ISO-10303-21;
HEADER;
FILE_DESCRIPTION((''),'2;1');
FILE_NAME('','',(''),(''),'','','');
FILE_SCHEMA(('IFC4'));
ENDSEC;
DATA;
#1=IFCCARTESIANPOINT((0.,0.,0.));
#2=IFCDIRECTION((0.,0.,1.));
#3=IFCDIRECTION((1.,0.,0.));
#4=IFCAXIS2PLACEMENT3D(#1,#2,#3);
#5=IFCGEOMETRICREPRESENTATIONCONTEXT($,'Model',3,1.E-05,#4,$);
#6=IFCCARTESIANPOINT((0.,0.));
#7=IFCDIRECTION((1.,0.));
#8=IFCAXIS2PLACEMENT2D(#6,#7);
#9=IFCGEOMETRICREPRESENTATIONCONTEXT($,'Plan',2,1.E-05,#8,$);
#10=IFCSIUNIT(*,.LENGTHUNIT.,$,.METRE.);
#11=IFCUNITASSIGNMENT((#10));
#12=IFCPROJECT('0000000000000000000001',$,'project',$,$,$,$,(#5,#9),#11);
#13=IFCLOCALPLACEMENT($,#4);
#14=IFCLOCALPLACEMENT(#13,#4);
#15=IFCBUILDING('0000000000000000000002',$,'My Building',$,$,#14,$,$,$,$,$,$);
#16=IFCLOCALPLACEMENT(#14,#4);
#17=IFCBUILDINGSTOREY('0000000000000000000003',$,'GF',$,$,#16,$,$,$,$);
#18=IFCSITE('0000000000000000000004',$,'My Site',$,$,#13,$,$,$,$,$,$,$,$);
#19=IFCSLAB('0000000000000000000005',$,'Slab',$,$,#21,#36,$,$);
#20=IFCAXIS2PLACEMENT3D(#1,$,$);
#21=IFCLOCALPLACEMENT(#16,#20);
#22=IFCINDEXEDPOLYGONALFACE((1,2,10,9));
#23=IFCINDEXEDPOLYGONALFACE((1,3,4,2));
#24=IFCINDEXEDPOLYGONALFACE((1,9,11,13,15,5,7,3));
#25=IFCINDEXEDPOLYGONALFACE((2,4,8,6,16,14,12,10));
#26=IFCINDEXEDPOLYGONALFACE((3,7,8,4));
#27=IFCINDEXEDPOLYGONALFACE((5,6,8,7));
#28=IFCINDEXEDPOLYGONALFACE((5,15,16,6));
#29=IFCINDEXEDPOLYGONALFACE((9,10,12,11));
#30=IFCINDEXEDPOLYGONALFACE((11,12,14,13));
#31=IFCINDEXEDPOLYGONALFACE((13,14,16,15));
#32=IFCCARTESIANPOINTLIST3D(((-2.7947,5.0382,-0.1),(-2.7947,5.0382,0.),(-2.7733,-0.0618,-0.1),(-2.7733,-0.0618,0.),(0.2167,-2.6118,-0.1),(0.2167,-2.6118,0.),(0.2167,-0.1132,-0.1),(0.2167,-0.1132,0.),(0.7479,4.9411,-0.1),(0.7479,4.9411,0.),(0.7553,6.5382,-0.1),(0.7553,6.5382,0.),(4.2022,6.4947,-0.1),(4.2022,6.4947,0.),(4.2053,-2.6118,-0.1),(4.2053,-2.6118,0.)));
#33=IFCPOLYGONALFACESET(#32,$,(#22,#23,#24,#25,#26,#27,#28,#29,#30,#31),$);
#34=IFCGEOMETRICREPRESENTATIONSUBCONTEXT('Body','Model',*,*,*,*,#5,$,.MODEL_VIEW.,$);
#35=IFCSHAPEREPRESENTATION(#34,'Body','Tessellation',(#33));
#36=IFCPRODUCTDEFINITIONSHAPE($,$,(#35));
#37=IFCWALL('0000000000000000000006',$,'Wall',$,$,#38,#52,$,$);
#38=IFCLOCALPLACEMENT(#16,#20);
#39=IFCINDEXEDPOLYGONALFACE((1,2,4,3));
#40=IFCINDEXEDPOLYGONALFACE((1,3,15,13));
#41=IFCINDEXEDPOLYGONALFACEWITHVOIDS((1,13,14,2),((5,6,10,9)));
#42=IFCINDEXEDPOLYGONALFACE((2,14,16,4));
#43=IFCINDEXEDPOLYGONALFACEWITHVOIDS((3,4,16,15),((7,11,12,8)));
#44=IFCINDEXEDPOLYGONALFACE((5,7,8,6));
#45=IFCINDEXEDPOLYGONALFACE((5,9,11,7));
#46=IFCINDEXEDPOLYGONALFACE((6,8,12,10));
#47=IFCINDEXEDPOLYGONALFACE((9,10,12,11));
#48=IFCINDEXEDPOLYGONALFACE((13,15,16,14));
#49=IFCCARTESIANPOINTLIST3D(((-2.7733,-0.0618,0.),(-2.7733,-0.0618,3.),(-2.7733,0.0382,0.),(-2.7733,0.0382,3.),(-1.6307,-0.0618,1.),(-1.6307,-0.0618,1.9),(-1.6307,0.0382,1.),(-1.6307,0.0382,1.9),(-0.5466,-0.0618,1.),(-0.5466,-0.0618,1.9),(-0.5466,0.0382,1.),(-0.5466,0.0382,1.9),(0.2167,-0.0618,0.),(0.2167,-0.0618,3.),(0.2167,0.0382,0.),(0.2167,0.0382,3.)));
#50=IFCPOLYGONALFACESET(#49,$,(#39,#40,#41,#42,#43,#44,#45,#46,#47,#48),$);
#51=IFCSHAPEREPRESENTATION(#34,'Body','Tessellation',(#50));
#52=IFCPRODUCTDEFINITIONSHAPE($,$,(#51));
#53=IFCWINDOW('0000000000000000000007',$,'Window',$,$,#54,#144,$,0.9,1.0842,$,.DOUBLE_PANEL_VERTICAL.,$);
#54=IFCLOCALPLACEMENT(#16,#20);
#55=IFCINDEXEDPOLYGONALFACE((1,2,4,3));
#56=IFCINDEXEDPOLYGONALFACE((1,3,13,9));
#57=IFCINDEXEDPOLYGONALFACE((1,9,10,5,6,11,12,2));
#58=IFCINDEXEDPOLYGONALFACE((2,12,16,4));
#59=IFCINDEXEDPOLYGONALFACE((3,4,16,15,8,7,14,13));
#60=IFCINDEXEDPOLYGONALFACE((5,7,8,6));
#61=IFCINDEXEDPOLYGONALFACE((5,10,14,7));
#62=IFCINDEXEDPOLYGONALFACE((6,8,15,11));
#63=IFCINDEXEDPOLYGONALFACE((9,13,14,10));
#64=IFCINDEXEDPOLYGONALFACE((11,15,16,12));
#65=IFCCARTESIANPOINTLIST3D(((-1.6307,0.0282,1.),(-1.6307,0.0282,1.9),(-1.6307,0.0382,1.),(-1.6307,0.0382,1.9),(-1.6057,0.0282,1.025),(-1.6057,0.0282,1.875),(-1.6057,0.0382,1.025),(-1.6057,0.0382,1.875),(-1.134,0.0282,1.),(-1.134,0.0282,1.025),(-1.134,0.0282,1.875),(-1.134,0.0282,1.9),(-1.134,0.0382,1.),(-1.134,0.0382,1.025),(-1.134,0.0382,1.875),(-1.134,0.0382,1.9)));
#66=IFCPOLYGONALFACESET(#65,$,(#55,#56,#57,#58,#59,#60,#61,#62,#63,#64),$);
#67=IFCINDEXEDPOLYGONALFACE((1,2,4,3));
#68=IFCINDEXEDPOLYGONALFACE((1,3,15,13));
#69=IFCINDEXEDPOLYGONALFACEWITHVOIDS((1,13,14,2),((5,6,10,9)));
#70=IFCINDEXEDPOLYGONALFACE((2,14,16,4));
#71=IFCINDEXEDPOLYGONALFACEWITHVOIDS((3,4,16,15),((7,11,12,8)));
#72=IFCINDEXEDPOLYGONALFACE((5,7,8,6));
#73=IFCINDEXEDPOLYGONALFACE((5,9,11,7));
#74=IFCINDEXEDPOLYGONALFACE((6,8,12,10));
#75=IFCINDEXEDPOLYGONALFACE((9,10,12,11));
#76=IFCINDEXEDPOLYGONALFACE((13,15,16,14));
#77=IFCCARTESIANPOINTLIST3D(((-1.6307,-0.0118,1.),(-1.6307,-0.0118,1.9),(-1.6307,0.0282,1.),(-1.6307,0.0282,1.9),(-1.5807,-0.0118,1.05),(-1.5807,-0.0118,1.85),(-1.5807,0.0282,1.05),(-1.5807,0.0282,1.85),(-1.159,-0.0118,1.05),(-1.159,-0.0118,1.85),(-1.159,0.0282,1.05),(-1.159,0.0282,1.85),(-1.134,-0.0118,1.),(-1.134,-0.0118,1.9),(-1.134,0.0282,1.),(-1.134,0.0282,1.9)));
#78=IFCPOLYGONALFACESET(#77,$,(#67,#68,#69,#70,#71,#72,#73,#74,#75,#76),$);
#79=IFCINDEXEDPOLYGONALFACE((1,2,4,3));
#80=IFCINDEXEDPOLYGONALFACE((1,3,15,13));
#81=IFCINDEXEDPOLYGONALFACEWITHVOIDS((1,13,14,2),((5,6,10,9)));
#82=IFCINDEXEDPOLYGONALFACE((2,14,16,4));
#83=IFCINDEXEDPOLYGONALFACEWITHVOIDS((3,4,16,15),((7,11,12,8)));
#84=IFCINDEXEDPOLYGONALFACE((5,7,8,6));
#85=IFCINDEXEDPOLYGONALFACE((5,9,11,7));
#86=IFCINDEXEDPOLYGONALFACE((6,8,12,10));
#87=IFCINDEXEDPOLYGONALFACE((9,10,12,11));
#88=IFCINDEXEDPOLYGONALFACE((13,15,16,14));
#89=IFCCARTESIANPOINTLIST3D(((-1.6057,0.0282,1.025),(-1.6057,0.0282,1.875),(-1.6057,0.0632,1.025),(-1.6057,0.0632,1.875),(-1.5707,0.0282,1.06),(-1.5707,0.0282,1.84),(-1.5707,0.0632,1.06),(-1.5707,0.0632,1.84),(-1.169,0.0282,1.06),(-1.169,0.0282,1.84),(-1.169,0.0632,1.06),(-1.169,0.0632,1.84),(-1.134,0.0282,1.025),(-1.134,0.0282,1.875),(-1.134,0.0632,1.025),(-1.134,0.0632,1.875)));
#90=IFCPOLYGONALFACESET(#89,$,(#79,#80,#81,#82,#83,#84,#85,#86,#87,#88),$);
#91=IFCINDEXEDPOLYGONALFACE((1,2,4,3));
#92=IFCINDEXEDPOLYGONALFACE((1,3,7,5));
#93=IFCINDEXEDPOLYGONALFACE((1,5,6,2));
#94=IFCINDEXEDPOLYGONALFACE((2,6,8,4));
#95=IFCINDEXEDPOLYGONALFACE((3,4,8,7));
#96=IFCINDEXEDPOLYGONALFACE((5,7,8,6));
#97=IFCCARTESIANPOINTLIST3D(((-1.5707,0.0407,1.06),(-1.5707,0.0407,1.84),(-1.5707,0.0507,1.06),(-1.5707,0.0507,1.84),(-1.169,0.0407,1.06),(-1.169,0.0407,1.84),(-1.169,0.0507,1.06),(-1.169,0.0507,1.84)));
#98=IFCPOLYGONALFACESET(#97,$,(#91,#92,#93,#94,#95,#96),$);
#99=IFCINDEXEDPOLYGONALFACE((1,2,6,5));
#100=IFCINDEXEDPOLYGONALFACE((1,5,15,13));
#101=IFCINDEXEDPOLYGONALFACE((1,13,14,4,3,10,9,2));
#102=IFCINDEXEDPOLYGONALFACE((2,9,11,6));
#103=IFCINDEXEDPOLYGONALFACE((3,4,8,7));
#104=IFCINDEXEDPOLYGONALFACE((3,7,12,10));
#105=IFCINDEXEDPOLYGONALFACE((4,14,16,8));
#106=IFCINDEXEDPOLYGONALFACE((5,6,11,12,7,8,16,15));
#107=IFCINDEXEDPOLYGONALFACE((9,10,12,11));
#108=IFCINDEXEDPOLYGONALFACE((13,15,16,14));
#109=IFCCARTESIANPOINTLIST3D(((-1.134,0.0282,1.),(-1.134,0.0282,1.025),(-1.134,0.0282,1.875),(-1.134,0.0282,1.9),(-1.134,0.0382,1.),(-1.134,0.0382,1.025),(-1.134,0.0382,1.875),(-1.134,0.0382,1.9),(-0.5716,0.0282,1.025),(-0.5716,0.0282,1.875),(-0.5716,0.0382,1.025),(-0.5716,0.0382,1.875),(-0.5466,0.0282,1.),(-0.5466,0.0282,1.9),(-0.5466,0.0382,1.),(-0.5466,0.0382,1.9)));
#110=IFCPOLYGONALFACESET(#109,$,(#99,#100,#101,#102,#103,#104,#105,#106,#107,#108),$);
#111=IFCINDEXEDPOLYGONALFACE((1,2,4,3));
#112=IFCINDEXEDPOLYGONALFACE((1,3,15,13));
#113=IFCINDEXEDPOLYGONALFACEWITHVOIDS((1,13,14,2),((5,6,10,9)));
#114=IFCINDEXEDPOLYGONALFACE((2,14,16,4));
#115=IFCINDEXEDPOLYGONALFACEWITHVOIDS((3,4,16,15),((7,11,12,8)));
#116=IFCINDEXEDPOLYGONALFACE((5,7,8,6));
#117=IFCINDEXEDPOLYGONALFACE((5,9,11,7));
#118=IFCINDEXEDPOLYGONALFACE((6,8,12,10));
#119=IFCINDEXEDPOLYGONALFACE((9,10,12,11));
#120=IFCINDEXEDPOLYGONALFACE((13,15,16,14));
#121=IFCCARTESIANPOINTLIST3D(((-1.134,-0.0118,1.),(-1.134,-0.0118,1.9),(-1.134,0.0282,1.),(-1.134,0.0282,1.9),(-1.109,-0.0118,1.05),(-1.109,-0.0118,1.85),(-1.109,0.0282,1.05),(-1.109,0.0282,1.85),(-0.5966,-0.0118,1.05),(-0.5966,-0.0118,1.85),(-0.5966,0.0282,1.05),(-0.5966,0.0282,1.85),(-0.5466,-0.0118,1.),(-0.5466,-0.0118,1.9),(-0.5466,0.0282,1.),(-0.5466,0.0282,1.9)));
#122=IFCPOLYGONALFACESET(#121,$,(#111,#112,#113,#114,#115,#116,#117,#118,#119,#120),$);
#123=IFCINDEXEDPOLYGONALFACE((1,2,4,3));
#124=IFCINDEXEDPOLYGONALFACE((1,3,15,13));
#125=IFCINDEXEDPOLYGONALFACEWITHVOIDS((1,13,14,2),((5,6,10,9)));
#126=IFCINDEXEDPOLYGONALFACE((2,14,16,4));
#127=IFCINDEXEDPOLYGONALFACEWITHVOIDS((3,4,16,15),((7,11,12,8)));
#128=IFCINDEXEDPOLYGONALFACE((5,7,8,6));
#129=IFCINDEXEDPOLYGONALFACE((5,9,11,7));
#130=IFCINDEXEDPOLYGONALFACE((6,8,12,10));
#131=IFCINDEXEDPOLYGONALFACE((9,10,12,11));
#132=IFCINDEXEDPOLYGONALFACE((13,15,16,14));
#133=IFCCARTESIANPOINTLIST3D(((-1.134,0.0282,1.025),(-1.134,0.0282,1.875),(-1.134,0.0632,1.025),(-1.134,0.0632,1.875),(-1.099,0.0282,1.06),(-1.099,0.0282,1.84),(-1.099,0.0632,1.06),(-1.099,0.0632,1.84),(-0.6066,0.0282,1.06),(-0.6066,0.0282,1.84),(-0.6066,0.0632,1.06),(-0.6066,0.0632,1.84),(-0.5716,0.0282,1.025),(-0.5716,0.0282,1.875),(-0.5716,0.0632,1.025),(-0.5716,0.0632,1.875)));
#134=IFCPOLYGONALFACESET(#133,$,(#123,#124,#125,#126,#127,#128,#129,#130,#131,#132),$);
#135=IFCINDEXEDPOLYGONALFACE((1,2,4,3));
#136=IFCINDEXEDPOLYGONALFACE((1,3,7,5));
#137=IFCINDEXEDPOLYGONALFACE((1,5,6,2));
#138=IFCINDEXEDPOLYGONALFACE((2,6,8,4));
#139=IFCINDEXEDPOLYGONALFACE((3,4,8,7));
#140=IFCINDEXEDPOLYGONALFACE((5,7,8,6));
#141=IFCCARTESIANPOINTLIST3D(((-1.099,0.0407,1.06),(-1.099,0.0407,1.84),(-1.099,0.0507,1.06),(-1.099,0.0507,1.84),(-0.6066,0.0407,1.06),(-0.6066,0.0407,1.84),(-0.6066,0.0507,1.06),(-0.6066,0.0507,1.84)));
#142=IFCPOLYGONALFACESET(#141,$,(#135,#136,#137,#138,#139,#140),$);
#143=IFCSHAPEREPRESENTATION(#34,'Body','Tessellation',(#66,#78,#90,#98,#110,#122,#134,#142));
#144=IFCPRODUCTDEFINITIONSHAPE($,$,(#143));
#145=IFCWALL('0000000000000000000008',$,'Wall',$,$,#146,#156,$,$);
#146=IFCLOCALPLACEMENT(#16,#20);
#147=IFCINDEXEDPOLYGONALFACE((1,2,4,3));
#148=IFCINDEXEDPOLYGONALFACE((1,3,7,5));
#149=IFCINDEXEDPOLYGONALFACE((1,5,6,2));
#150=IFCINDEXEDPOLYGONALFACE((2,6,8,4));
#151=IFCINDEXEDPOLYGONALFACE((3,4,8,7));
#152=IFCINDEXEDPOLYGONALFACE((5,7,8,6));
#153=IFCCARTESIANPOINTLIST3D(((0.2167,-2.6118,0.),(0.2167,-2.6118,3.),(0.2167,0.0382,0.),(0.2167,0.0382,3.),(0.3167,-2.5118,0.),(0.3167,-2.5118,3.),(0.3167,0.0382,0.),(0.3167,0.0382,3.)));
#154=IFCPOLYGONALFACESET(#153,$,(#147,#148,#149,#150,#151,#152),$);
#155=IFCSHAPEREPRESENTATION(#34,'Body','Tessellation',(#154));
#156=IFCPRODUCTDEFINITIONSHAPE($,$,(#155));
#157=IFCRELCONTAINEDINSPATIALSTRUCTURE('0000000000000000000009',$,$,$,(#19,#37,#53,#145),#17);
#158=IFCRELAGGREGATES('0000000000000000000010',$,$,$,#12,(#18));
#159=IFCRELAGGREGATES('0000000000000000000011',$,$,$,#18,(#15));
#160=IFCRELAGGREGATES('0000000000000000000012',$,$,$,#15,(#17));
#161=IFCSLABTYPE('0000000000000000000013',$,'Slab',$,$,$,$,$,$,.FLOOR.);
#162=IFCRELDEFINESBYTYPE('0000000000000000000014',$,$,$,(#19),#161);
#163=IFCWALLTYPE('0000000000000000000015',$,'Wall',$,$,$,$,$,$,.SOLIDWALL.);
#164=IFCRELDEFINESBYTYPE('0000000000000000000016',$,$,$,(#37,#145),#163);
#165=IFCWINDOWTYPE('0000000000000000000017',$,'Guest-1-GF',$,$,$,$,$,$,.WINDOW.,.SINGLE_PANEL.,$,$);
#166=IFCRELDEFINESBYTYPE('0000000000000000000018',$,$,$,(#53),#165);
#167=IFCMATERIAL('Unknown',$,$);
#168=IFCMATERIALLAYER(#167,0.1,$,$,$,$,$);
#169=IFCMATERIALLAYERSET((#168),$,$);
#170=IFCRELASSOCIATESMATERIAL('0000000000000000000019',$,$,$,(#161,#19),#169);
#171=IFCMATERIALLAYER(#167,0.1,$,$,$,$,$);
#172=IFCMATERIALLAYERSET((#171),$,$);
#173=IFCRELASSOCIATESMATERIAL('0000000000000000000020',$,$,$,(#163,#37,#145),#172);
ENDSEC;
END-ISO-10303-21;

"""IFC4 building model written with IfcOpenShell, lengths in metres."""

from ifc_helpers import new_model, entity, si_unit, frame, origin_with_axes, origin_2d_with_axis, place, context, subcontext, project, spatial, line, indexed_curve, outline, extrude, shape, source, transform, mapped, material, layer, layer_set, layer_usage, type_object, type_shapes, element, fill, save


model = new_model("IFC4")

# Units and contexts
model_context = context("Model", 3, precision=1e-05, world=origin_with_axes())
plan_context = context("Plan", 2, precision=1e-05, world=origin_2d_with_axis())
body_context_1 = subcontext(model_context, "Body", "Model", "MODEL_VIEW")
body_context_2 = subcontext(plan_context, "Body", "Plan", "PLAN_VIEW")
ifc_project = project(units=[si_unit("LENGTHUNIT", "METRE")], contexts=[model_context, plan_context])

# Site, building, storey
site_placement = place(None, origin_with_axes())
site = spatial("IfcSite", under=ifc_project, at=site_placement, Name="My Site")
building_placement = place(site_placement, origin_with_axes())
building = spatial("IfcBuilding", under=site, at=building_placement, Name="My Building")
storey_placement = place(building_placement, origin_with_axes())
storey = spatial("IfcBuildingStorey", under=building, at=storey_placement, Name="GF")

# Slab
ifc_material = material(Name="Unknown")
ifc_layer_1 = layer(ifc_material, 0.1)
ifc_layer_set_1 = layer_set([ifc_layer_1])
ifc_layer_usage_1 = layer_usage(ifc_layer_set_1, "AXIS3", "POSITIVE", -0.1)
slab_type = type_object("IfcSlabType", Name="Slab", PredefinedType="FLOOR", material=ifc_layer_set_1)
slab_placement = place(storey_placement, frame((4.2022, 6.4947, 0.0), z_axis=(0.0, 0.0, 1.0), x_axis=(1.0, 0.0, 0.0)))
element("IfcSlab", 1, at=slab_placement, inside=storey, type_object=slab_type, material=ifc_layer_usage_1, Name="Slab", context=body_context_1, shape_type="SweptSolid", body=[
    extrude(outline(indexed_curve([(0.0, 0.0), (-3.4469, 0.0435), (-3.4543, -1.5535), (-6.9969, -1.4565), (-6.9755, -6.5565), (-3.9855, -6.6078), (-3.9855, -9.1065), (0.0031, -9.1065), (0.0, 0.0)])), frame((0.0, 0.0, -0.1), z_axis=(0.0, 0.0, 1.0), x_axis=(1.0, 0.0, 0.0)), (0.0, 0.0, 1.0), 0.1),
])

# Wall, opening, window
ifc_layer_2 = layer(ifc_material, 0.1)
ifc_layer_set_2 = layer_set([ifc_layer_2])
ifc_layer_usage_2 = layer_usage(ifc_layer_set_2, "AXIS2", "POSITIVE", 0.0)
wall_type = type_object("IfcWallType", Name="Wall", PredefinedType="SOLIDWALL", material=ifc_layer_set_2)
wall_1_placement = place(storey_placement, frame((0.2167, 0.0382, 0.0), z_axis=(0.0, 0.0, 1.0), x_axis=(-1.0, 0.0, 0.0)))
wall_1 = element("IfcWall", 2, at=wall_1_placement, inside=storey, type_object=wall_type, material=ifc_layer_usage_2, Name="Wall", context=body_context_1, shape_type="SweptSolid", body=[
    extrude(outline(indexed_curve([(0.0, 0.0), (0.0, 0.1), (2.99, 0.1), (2.99, 0.0)], segments=[line(1, 2, 3, 4, 1)])), origin_with_axes(), (0.0, 0.0, 1.0), 3.0),
])
shared_shape_1 = source(origin_with_axes(), body_context_1, "Body", "SweptSolid", [
    extrude(outline(indexed_curve([(0.0, 0.0), (1.0842, 0.0), (1.0842, 0.9), (0.0, 0.9)], segments=[line(1, 2, 3, 4, 1)])), frame((0.0, -0.6, 0.0), z_axis=(0.0, -1.0, 0.0), x_axis=(1.0, 0.0, 0.0)), (0.0, 0.0, -1.0), 1.2),
])
opening_1_placement = place(wall_1_placement, frame((1.8474, 0.1, 1.0), z_axis=(0.0, 0.0, 1.0), x_axis=(-1.0, 0.0, 0.0)))
opening_1 = element("IfcOpeningElement", 3, at=opening_1_placement, cuts=wall_1, PredefinedType="OPENING", context=body_context_1, shape_type="MappedRepresentation", body=[
    mapped(shared_shape_1, transform((0.0, 0.0, 0.0), x_axis=(1.0, 0.0, 0.0), y_axis=(0.0, 1.0, 0.0), z_axis=(0.0, 0.0, 1.0), scale=1.0)),
])
window_type_1 = type_object("IfcWindowType", Name="Guest-1-GF", PartitioningType="SINGLE_PANEL", PredefinedType="WINDOW")
shared_shape_2 = source(origin_with_axes(), body_context_1, "Body", "SweptSolid", [
    extrude(outline(indexed_curve([(0.4967, 0.0), (0.0, 0.0), (0.0, 0.9), (0.4967, 0.9), (0.4967, 0.875), (0.025, 0.875), (0.025, 0.025), (0.4967, 0.025)], segments=[line(1, 2, 3, 4, 5, 6, 7, 8, 1)])), frame((0.0, 0.09, 0.0), z_axis=(0.0, -1.0, 0.0), x_axis=(1.0, 0.0, 0.0)), (0.0, 0.0, -1.0), 0.01),
    extrude(outline(indexed_curve([(0.0, 0.0), (0.4967, 0.0), (0.4967, 0.9), (0.0, 0.9)], segments=[line(1, 2, 3, 4, 1)]), holes=[indexed_curve([(0.05, 0.05), (0.4717, 0.05), (0.4717, 0.85), (0.05, 0.85)], segments=[line(1, 2, 3, 4, 1)])]), frame((0.0, 0.05, 0.0), z_axis=(0.0, -1.0, 0.0), x_axis=(1.0, 0.0, 0.0)), (0.0, 0.0, -1.0), 0.04),
    extrude(outline(indexed_curve([(0.0, 0.0), (0.4717, 0.0), (0.4717, 0.85), (0.0, 0.85)], segments=[line(1, 2, 3, 4, 1)]), holes=[indexed_curve([(0.035, 0.035), (0.4367, 0.035), (0.4367, 0.815), (0.035, 0.815)], segments=[line(1, 2, 3, 4, 1)])]), frame((0.025, 0.09, 0.025), z_axis=(0.0, -1.0, 0.0), x_axis=(1.0, 0.0, 0.0)), (0.0, 0.0, -1.0), 0.035),
    extrude(outline(indexed_curve([(0.035, 0.035), (0.4367, 0.035), (0.4367, 0.815), (0.035, 0.815)], segments=[line(1, 2, 3, 4, 1)])), frame((0.025, 0.1025, 0.025), z_axis=(0.0, -1.0, 0.0), x_axis=(1.0, 0.0, 0.0)), (0.0, 0.0, -1.0), 0.01),
    extrude(outline(indexed_curve([(0.0, 0.9), (0.5874, 0.9), (0.5874, 0.0), (0.0, 0.0), (0.0, 0.025), (0.5624, 0.025), (0.5624, 0.875), (0.0, 0.875)], segments=[line(1, 2, 3, 4, 5, 6, 7, 8, 1)])), frame((0.4967, 0.09, 0.0), z_axis=(0.0, -1.0, 0.0), x_axis=(1.0, 0.0, 0.0)), (0.0, 0.0, -1.0), 0.01),
    extrude(outline(indexed_curve([(0.0, 0.0), (0.5874, 0.0), (0.5874, 0.9), (0.0, 0.9)], segments=[line(1, 2, 3, 4, 1)]), holes=[indexed_curve([(0.025, 0.05), (0.5374, 0.05), (0.5374, 0.85), (0.025, 0.85)], segments=[line(1, 2, 3, 4, 1)])]), frame((0.4967, 0.05, 0.0), z_axis=(0.0, -1.0, 0.0), x_axis=(1.0, 0.0, 0.0)), (0.0, 0.0, -1.0), 0.04),
    extrude(outline(indexed_curve([(0.0, 0.0), (0.5624, 0.0), (0.5624, 0.85), (0.0, 0.85)], segments=[line(1, 2, 3, 4, 1)]), holes=[indexed_curve([(0.035, 0.035), (0.5274, 0.035), (0.5274, 0.815), (0.035, 0.815)], segments=[line(1, 2, 3, 4, 1)])]), frame((0.4967, 0.09, 0.025), z_axis=(0.0, -1.0, 0.0), x_axis=(1.0, 0.0, 0.0)), (0.0, 0.0, -1.0), 0.035),
    extrude(outline(indexed_curve([(0.035, 0.035), (0.5274, 0.035), (0.5274, 0.815), (0.035, 0.815)], segments=[line(1, 2, 3, 4, 1)])), frame((0.4967, 0.1025, 0.025), z_axis=(0.0, -1.0, 0.0), x_axis=(1.0, 0.0, 0.0)), (0.0, 0.0, -1.0), 0.01),
])
shared_shape_3 = source(origin_with_axes(), body_context_2, "Body", "Curve2D", [
    entity("IfcIndexedPolyCurve", entity("IfcCartesianPointList2D", [[0.05, 0.05], [0.4717, 0.05]])),
    entity("IfcIndexedPolyCurve", entity("IfcCartesianPointList2D", [[0.0, 0.1], [0.025, 0.1], [0.025, 0.09], [0.05, 0.09], [0.05, 0.05], [0.0, 0.05]]), [entity("IfcLineIndex", [1, 2, 3, 4, 5, 6, 1])]),
    entity("IfcIndexedPolyCurve", entity("IfcCartesianPointList2D", [[0.4967, 0.1], [0.4967, 0.1], [0.4967, 0.09], [0.4717, 0.09], [0.4717, 0.05], [0.4967, 0.05]])),
    entity("IfcIndexedPolyCurve", entity("IfcCartesianPointList2D", [[0.025, 0.09], [0.06, 0.09], [0.06, 0.125], [0.025, 0.125]]), [entity("IfcLineIndex", [1, 2, 3, 4, 1])]),
    entity("IfcIndexedPolyCurve", entity("IfcCartesianPointList2D", [[0.4967, 0.09], [0.4617, 0.09], [0.4617, 0.125], [0.4967, 0.125]]), [entity("IfcLineIndex", [1, 2, 3, 4, 1])]),
    entity("IfcIndexedPolyCurve", entity("IfcCartesianPointList2D", [[0.06, 0.09], [0.4617, 0.09]])),
    entity("IfcIndexedPolyCurve", entity("IfcCartesianPointList2D", [[0.06, 0.125], [0.4617, 0.125]])),
    entity("IfcIndexedPolyCurve", entity("IfcCartesianPointList2D", [[0.06, 0.1075], [0.4617, 0.1075]])),
    entity("IfcIndexedPolyCurve", entity("IfcCartesianPointList2D", [[0.5217, 0.05], [1.0342, 0.05]])),
    entity("IfcIndexedPolyCurve", entity("IfcCartesianPointList2D", [[0.4967, 0.1], [0.4967, 0.1], [0.4967, 0.09], [0.5217, 0.09], [0.5217, 0.05], [0.4967, 0.05]])),
    entity("IfcIndexedPolyCurve", entity("IfcCartesianPointList2D", [[1.0842, 0.1], [1.0592, 0.1], [1.0592, 0.09], [1.0342, 0.09], [1.0342, 0.05], [1.0842, 0.05]]), [entity("IfcLineIndex", [1, 2, 3, 4, 5, 6, 1])]),
    entity("IfcIndexedPolyCurve", entity("IfcCartesianPointList2D", [[0.4967, 0.09], [0.5317, 0.09], [0.5317, 0.125], [0.4967, 0.125]]), [entity("IfcLineIndex", [1, 2, 3, 4, 1])]),
    entity("IfcIndexedPolyCurve", entity("IfcCartesianPointList2D", [[1.0592, 0.09], [1.0242, 0.09], [1.0242, 0.125], [1.0592, 0.125]]), [entity("IfcLineIndex", [1, 2, 3, 4, 1])]),
    entity("IfcIndexedPolyCurve", entity("IfcCartesianPointList2D", [[0.5317, 0.09], [1.0242, 0.09]])),
    entity("IfcIndexedPolyCurve", entity("IfcCartesianPointList2D", [[0.5317, 0.125], [1.0242, 0.125]])),
    entity("IfcIndexedPolyCurve", entity("IfcCartesianPointList2D", [[0.5317, 0.1075], [1.0242, 0.1075]])),
])
type_shapes(window_type_1, [shared_shape_2, shared_shape_3])
window_1_placement = place(opening_1_placement, frame((0.0, 0.0, 0.0), z_axis=(0.0, 0.0, 1.0), x_axis=(1.0, 0.0, 0.0)))
window_1 = element("IfcWindow", 4, at=window_1_placement, inside=storey, type_object=window_type_1, Name="Window", OverallHeight=0.9, OverallWidth=1.0842, PartitioningType="DOUBLE_PANEL_VERTICAL", shapes=[
    shape(body_context_1, "Body", "MappedRepresentation", [mapped(shared_shape_2, transform((0.0, 0.0, 0.0), x_axis=(1.0, 0.0, 0.0), y_axis=(0.0, 1.0, 0.0), z_axis=(0.0, 0.0, 1.0), scale=1.0))]),
    shape(body_context_2, "Body", "MappedRepresentation", [mapped(shared_shape_3, transform((0.0, 0.0, 0.0), x_axis=(1.0, 0.0, 0.0), y_axis=(0.0, 1.0, 0.0), z_axis=(0.0, 0.0, 1.0), scale=1.0))]),
])
fill(opening_1, window_1)

# Wall
ifc_layer_usage_3 = layer_usage(ifc_layer_set_2, "AXIS2", "POSITIVE", 0.0)
wall_2_placement = place(storey_placement, frame((0.2167, 0.0382, 0.0), z_axis=(0.0, 0.0, 1.0), x_axis=(0.0, -1.0, 0.0)))
element("IfcWall", 5, at=wall_2_placement, inside=storey, type_object=wall_type, material=ifc_layer_usage_3, Name="Wall", context=body_context_1, shape_type="SweptSolid", body=[
    extrude(outline(indexed_curve([(0.0, 0.0), (0.0, 0.1), (2.55, 0.1), (2.65, 0.0)], segments=[line(1, 2, 3, 4, 1)])), origin_with_axes(), (0.0, 0.0, 1.0), 3.0),
])

save(model, "model.ifc")
